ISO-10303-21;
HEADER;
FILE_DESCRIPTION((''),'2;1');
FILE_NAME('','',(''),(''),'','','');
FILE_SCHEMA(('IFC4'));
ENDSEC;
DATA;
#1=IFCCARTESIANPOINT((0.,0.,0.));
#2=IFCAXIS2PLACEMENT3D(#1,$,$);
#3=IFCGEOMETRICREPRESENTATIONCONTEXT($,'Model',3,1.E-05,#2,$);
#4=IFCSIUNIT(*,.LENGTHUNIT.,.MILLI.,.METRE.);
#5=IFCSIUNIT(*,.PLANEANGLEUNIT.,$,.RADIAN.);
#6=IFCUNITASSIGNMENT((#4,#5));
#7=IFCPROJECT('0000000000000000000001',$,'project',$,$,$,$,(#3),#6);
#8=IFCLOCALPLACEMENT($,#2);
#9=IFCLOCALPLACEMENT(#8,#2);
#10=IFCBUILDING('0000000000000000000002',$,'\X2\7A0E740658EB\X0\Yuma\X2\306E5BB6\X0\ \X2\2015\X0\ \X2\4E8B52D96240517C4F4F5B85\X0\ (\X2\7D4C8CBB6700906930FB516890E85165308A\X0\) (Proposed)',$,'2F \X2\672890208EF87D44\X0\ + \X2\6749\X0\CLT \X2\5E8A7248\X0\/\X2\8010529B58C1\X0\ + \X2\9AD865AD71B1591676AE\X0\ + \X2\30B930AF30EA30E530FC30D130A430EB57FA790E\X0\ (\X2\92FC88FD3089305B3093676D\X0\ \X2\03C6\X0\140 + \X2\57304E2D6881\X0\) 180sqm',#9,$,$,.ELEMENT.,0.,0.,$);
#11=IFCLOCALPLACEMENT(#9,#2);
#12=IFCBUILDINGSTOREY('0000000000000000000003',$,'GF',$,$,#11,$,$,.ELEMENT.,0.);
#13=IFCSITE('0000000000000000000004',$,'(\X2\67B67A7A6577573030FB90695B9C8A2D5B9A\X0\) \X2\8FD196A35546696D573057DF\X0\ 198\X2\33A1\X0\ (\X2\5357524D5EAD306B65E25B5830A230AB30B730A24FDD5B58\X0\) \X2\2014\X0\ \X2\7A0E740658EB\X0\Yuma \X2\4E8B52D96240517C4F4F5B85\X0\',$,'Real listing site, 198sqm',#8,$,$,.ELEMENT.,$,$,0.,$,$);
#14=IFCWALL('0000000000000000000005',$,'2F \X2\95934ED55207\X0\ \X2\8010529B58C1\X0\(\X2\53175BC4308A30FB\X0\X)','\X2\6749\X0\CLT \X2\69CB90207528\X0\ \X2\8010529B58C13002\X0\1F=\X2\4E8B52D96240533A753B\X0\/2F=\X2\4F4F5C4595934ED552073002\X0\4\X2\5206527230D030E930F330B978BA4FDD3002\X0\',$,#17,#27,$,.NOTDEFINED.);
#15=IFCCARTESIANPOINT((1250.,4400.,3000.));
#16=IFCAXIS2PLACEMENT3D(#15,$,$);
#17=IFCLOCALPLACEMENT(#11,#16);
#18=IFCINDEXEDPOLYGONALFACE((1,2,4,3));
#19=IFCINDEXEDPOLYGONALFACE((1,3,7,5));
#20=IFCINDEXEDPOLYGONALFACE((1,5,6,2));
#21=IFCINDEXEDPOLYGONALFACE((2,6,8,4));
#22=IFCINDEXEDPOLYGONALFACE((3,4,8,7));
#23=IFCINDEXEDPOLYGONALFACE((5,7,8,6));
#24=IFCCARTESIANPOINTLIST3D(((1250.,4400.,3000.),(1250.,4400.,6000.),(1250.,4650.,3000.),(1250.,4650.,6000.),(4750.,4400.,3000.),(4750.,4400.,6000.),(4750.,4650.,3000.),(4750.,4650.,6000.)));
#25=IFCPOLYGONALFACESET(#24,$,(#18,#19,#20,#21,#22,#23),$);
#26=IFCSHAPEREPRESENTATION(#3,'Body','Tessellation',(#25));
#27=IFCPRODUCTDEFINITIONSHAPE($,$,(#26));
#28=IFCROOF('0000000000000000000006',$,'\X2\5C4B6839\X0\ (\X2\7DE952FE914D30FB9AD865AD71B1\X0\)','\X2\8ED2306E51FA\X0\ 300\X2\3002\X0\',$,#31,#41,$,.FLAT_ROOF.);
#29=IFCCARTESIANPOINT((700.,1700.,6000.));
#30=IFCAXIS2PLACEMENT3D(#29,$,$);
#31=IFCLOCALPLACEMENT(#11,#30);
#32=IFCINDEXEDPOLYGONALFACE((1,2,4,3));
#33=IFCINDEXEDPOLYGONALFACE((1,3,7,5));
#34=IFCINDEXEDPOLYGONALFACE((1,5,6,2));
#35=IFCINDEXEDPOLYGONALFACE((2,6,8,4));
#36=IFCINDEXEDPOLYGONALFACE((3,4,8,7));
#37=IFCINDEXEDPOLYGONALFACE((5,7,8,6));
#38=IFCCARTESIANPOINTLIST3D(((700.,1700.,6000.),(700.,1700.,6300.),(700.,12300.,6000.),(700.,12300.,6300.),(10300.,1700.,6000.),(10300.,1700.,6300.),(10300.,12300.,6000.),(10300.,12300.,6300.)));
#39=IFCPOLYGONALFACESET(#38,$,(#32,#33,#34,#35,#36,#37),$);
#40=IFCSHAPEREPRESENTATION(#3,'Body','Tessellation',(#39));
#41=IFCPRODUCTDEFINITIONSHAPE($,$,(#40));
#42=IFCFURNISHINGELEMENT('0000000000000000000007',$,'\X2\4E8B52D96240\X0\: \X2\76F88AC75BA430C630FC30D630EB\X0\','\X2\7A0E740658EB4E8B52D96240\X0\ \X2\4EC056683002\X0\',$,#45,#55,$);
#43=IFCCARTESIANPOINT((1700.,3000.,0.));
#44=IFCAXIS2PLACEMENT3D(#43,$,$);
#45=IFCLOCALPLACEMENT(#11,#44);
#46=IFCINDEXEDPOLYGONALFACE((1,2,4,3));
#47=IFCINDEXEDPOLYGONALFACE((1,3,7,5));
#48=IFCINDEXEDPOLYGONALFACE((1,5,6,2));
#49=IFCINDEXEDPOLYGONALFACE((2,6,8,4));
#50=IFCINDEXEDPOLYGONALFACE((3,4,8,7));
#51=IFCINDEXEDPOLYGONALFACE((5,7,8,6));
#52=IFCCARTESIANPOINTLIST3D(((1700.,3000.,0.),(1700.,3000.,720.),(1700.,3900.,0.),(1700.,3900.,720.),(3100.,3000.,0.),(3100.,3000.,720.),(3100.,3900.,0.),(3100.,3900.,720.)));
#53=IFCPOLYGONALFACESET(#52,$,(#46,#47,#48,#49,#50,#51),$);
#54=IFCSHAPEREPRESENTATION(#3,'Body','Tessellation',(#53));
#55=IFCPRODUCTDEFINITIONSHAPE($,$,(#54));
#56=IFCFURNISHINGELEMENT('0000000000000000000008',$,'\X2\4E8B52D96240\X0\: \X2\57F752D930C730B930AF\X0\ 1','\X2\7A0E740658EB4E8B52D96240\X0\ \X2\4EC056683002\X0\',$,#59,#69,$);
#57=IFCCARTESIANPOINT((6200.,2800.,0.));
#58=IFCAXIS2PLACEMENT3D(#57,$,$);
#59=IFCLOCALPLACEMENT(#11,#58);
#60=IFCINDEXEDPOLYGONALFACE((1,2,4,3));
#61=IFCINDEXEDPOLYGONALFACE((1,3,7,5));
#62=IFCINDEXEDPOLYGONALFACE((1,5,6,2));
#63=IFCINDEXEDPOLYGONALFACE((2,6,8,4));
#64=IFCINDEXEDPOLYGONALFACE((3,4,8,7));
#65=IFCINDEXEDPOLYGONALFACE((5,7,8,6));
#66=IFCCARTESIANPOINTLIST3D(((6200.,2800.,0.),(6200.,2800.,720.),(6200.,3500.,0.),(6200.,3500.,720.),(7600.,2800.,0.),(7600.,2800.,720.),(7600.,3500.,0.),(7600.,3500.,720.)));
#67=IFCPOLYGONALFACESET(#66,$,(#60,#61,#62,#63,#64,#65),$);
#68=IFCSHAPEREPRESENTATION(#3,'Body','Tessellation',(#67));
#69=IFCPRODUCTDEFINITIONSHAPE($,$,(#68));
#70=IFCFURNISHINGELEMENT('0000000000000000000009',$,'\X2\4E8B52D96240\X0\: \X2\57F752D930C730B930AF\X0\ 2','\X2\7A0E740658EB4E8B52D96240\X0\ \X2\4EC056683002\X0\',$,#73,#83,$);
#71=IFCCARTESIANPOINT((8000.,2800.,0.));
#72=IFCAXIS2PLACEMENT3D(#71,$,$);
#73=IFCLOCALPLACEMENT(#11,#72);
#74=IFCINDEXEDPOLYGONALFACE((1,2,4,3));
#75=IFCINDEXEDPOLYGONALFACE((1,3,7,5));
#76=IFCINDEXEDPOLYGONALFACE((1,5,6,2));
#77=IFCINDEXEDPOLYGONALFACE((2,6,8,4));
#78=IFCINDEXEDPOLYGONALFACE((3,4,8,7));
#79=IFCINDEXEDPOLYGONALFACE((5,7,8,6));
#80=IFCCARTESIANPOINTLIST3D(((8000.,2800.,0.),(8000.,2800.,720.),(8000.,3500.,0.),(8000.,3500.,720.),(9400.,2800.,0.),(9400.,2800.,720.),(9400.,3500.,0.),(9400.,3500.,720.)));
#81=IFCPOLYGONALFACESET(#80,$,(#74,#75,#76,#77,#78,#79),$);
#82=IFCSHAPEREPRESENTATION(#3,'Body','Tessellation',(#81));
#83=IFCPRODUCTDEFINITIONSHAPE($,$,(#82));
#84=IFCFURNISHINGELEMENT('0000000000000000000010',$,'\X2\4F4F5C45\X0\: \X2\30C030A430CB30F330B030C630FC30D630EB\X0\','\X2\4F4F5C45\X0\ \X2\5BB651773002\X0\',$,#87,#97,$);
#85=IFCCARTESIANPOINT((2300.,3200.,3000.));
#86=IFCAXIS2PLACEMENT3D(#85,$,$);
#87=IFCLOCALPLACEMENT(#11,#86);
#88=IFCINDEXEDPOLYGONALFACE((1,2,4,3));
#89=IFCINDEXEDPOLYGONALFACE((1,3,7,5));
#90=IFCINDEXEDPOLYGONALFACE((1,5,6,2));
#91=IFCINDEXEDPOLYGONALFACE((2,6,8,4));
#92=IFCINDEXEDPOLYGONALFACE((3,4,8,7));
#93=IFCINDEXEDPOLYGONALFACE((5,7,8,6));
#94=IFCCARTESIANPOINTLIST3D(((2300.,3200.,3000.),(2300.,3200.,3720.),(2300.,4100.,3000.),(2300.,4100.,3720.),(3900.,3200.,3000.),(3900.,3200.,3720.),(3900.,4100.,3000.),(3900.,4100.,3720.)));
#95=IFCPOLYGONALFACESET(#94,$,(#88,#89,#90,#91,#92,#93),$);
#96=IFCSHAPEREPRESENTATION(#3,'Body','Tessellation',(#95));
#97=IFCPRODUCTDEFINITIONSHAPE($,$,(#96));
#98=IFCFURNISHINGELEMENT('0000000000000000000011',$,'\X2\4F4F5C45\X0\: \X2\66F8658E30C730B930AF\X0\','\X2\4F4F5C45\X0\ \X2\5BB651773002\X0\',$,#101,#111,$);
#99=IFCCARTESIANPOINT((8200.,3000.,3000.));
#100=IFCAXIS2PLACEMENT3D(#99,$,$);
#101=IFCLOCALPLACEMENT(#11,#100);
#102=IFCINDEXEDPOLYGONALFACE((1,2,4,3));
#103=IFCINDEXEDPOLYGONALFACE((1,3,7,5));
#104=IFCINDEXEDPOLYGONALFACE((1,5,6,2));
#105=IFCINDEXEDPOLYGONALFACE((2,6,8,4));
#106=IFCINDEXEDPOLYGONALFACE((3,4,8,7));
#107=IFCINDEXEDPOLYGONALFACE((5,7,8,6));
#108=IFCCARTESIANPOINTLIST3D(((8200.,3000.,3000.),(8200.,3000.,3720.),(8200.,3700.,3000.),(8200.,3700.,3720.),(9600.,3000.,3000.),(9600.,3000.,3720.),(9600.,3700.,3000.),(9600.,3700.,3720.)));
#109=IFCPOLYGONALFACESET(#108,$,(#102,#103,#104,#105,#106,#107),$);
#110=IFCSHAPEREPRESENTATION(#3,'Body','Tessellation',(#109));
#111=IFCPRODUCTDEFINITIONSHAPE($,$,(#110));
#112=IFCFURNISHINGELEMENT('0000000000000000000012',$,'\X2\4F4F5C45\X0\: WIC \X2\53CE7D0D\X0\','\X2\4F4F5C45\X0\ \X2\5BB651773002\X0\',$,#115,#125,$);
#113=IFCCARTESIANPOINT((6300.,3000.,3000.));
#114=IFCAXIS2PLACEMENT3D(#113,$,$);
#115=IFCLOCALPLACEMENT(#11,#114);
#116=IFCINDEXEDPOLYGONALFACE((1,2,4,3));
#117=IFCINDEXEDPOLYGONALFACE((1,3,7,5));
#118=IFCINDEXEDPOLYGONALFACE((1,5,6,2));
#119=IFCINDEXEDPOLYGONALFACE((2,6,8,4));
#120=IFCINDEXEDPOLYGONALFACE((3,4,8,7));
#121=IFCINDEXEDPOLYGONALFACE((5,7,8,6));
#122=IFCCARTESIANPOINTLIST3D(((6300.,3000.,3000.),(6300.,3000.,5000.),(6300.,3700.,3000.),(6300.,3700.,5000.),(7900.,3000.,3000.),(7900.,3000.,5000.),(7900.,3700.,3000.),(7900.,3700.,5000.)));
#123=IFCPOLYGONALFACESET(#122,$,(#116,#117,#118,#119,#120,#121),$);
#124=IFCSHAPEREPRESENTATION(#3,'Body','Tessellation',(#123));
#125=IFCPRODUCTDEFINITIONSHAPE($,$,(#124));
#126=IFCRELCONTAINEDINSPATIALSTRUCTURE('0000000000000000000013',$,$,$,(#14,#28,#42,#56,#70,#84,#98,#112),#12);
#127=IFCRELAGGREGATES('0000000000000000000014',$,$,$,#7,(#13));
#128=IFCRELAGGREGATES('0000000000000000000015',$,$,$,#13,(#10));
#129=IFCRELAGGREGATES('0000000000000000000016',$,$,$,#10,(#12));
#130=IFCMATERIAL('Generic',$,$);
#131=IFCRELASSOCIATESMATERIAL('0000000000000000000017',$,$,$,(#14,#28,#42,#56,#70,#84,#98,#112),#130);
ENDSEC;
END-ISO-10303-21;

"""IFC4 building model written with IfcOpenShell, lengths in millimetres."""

from ifc_helpers import new_model, si_unit, frame, frame_2d, origin, place, context, project, spatial, rectangle, extrude, material, element, save


model = new_model("IFC4")

# Units and contexts
model_context = context("Model", 3, precision=1e-05, world=origin())
ifc_project = project(units=[si_unit("LENGTHUNIT", "METRE", prefix="MILLI"), si_unit("PLANEANGLEUNIT", "RADIAN")], contexts=[model_context])

# Site, building, storey
site_placement = place(None, origin())
site = spatial("IfcSite", under=ifc_project, at=site_placement, Name="(架空敷地・適宜設定) 近隣商業地域 198㎡ (南前庭に既存アカシア保存) — 税理士Yuma 事務所兼住宅", ObjectType="Real listing site, 198sqm", CompositionType="ELEMENT", RefElevation=0.0)
building_placement = place(site_placement, origin())
building = spatial("IfcBuilding", under=site, at=building_placement, Name="税理士Yumaの家 ― 事務所兼住宅 (経費最適・全部入り) (Proposed)", ObjectType="2F 木造軸組 + 杉CLT 床版/耐力壁 + 高断熱外皮 + スクリューパイル基礎 (鋼製らせん杭 φ140 + 地中梁) 180sqm", CompositionType="ELEMENT", ElevationOfRefHeight=0.0, ElevationOfTerrain=0.0)
storey_placement = place(building_placement, origin())
storey = spatial("IfcBuildingStorey", under=building, at=storey_placement, Name="GF", CompositionType="ELEMENT", Elevation=0.0)

# Shared definitions
ifc_material_1 = material(Name="Generic")

# Wall
wall_1_placement = place(storey_placement, frame((1250.0, 4400.0, 3000.0)))
element("IfcWall", 1, at=wall_1_placement, inside=storey, material=ifc_material_1, Name="2F 間仕切 耐力壁(北寄り・X)", Description="杉CLT 構造用 耐力壁。1F=事務所区画/2F=住居間仕切。4分割バランス確保。", PredefinedType="NOTDEFINED", context=model_context, shape_type="SweptSolid", body=[
    extrude(rectangle(XDim=3500.0, YDim=250.0, at=frame_2d((1750.0, 125.0))), frame((1250.0, 4400.0, 3000.0)), (0.0, 0.0, 1.0), 3000.0),
])

# Roof
roof_placement = place(storey_placement, frame((700.0, 1700.0, 6000.0)))
element("IfcRoof", 2, at=roof_placement, inside=storey, material=ifc_material_1, Name="屋根 (緩勾配・高断熱)", Description="軒の出 300。", PredefinedType="FLAT_ROOF", context=model_context, shape_type="SweptSolid", body=[
    extrude(rectangle(XDim=9600.0, YDim=10600.0, at=frame_2d((4800.0, 5300.0))), frame((700.0, 1700.0, 6000.0)), (0.0, 0.0, 1.0), 300.0),
])

# Furnishing elements
furnishing_1_placement = place(storey_placement, frame((1700.0, 3000.0, 0.0)))
element("IfcFurnishingElement", 3, at=furnishing_1_placement, inside=storey, material=ifc_material_1, Name="事務所: 相談室テーブル", Description="税理士事務所 什器。", context=model_context, shape_type="SweptSolid", body=[
    extrude(rectangle(XDim=1400.0, YDim=900.0, at=frame_2d((700.0, 450.0))), frame((1700.0, 3000.0, 0.0)), (0.0, 0.0, 1.0), 720.0),
])
furnishing_2_placement = place(storey_placement, frame((6200.0, 2800.0, 0.0)))
element("IfcFurnishingElement", 4, at=furnishing_2_placement, inside=storey, material=ifc_material_1, Name="事務所: 執務デスク 1", Description="税理士事務所 什器。", context=model_context, shape_type="SweptSolid", body=[
    extrude(rectangle(XDim=1400.0, YDim=700.0, at=frame_2d((700.0, 350.0))), frame((6200.0, 2800.0, 0.0)), (0.0, 0.0, 1.0), 720.0),
])
furnishing_3_placement = place(storey_placement, frame((8000.0, 2800.0, 0.0)))
element("IfcFurnishingElement", 5, at=furnishing_3_placement, inside=storey, material=ifc_material_1, Name="事務所: 執務デスク 2", Description="税理士事務所 什器。", context=model_context, shape_type="SweptSolid", body=[
    extrude(rectangle(XDim=1400.0, YDim=700.0, at=frame_2d((700.0, 350.0))), frame((8000.0, 2800.0, 0.0)), (0.0, 0.0, 1.0), 720.0),
])
furnishing_4_placement = place(storey_placement, frame((2300.0, 3200.0, 3000.0)))
element("IfcFurnishingElement", 6, at=furnishing_4_placement, inside=storey, material=ifc_material_1, Name="住居: ダイニングテーブル", Description="住居 家具。", context=model_context, shape_type="SweptSolid", body=[
    extrude(rectangle(XDim=1600.0, YDim=900.0, at=frame_2d((800.0, 450.0))), frame((2300.0, 3200.0, 3000.0)), (0.0, 0.0, 1.0), 720.0),
])
furnishing_5_placement = place(storey_placement, frame((8200.0, 3000.0, 3000.0)))
element("IfcFurnishingElement", 7, at=furnishing_5_placement, inside=storey, material=ifc_material_1, Name="住居: 書斎デスク", Description="住居 家具。", context=model_context, shape_type="SweptSolid", body=[
    extrude(rectangle(XDim=1400.0, YDim=700.0, at=frame_2d((700.0, 350.0))), frame((8200.0, 3000.0, 3000.0)), (0.0, 0.0, 1.0), 720.0),
])
furnishing_6_placement = place(storey_placement, frame((6300.0, 3000.0, 3000.0)))
element("IfcFurnishingElement", 8, at=furnishing_6_placement, inside=storey, material=ifc_material_1, Name="住居: WIC 収納", Description="住居 家具。", context=model_context, shape_type="SweptSolid", body=[
    extrude(rectangle(XDim=1600.0, YDim=700.0, at=frame_2d((800.0, 350.0))), frame((6300.0, 3000.0, 3000.0)), (0.0, 0.0, 1.0), 2000.0),
])

save(model, "model.ifc")
